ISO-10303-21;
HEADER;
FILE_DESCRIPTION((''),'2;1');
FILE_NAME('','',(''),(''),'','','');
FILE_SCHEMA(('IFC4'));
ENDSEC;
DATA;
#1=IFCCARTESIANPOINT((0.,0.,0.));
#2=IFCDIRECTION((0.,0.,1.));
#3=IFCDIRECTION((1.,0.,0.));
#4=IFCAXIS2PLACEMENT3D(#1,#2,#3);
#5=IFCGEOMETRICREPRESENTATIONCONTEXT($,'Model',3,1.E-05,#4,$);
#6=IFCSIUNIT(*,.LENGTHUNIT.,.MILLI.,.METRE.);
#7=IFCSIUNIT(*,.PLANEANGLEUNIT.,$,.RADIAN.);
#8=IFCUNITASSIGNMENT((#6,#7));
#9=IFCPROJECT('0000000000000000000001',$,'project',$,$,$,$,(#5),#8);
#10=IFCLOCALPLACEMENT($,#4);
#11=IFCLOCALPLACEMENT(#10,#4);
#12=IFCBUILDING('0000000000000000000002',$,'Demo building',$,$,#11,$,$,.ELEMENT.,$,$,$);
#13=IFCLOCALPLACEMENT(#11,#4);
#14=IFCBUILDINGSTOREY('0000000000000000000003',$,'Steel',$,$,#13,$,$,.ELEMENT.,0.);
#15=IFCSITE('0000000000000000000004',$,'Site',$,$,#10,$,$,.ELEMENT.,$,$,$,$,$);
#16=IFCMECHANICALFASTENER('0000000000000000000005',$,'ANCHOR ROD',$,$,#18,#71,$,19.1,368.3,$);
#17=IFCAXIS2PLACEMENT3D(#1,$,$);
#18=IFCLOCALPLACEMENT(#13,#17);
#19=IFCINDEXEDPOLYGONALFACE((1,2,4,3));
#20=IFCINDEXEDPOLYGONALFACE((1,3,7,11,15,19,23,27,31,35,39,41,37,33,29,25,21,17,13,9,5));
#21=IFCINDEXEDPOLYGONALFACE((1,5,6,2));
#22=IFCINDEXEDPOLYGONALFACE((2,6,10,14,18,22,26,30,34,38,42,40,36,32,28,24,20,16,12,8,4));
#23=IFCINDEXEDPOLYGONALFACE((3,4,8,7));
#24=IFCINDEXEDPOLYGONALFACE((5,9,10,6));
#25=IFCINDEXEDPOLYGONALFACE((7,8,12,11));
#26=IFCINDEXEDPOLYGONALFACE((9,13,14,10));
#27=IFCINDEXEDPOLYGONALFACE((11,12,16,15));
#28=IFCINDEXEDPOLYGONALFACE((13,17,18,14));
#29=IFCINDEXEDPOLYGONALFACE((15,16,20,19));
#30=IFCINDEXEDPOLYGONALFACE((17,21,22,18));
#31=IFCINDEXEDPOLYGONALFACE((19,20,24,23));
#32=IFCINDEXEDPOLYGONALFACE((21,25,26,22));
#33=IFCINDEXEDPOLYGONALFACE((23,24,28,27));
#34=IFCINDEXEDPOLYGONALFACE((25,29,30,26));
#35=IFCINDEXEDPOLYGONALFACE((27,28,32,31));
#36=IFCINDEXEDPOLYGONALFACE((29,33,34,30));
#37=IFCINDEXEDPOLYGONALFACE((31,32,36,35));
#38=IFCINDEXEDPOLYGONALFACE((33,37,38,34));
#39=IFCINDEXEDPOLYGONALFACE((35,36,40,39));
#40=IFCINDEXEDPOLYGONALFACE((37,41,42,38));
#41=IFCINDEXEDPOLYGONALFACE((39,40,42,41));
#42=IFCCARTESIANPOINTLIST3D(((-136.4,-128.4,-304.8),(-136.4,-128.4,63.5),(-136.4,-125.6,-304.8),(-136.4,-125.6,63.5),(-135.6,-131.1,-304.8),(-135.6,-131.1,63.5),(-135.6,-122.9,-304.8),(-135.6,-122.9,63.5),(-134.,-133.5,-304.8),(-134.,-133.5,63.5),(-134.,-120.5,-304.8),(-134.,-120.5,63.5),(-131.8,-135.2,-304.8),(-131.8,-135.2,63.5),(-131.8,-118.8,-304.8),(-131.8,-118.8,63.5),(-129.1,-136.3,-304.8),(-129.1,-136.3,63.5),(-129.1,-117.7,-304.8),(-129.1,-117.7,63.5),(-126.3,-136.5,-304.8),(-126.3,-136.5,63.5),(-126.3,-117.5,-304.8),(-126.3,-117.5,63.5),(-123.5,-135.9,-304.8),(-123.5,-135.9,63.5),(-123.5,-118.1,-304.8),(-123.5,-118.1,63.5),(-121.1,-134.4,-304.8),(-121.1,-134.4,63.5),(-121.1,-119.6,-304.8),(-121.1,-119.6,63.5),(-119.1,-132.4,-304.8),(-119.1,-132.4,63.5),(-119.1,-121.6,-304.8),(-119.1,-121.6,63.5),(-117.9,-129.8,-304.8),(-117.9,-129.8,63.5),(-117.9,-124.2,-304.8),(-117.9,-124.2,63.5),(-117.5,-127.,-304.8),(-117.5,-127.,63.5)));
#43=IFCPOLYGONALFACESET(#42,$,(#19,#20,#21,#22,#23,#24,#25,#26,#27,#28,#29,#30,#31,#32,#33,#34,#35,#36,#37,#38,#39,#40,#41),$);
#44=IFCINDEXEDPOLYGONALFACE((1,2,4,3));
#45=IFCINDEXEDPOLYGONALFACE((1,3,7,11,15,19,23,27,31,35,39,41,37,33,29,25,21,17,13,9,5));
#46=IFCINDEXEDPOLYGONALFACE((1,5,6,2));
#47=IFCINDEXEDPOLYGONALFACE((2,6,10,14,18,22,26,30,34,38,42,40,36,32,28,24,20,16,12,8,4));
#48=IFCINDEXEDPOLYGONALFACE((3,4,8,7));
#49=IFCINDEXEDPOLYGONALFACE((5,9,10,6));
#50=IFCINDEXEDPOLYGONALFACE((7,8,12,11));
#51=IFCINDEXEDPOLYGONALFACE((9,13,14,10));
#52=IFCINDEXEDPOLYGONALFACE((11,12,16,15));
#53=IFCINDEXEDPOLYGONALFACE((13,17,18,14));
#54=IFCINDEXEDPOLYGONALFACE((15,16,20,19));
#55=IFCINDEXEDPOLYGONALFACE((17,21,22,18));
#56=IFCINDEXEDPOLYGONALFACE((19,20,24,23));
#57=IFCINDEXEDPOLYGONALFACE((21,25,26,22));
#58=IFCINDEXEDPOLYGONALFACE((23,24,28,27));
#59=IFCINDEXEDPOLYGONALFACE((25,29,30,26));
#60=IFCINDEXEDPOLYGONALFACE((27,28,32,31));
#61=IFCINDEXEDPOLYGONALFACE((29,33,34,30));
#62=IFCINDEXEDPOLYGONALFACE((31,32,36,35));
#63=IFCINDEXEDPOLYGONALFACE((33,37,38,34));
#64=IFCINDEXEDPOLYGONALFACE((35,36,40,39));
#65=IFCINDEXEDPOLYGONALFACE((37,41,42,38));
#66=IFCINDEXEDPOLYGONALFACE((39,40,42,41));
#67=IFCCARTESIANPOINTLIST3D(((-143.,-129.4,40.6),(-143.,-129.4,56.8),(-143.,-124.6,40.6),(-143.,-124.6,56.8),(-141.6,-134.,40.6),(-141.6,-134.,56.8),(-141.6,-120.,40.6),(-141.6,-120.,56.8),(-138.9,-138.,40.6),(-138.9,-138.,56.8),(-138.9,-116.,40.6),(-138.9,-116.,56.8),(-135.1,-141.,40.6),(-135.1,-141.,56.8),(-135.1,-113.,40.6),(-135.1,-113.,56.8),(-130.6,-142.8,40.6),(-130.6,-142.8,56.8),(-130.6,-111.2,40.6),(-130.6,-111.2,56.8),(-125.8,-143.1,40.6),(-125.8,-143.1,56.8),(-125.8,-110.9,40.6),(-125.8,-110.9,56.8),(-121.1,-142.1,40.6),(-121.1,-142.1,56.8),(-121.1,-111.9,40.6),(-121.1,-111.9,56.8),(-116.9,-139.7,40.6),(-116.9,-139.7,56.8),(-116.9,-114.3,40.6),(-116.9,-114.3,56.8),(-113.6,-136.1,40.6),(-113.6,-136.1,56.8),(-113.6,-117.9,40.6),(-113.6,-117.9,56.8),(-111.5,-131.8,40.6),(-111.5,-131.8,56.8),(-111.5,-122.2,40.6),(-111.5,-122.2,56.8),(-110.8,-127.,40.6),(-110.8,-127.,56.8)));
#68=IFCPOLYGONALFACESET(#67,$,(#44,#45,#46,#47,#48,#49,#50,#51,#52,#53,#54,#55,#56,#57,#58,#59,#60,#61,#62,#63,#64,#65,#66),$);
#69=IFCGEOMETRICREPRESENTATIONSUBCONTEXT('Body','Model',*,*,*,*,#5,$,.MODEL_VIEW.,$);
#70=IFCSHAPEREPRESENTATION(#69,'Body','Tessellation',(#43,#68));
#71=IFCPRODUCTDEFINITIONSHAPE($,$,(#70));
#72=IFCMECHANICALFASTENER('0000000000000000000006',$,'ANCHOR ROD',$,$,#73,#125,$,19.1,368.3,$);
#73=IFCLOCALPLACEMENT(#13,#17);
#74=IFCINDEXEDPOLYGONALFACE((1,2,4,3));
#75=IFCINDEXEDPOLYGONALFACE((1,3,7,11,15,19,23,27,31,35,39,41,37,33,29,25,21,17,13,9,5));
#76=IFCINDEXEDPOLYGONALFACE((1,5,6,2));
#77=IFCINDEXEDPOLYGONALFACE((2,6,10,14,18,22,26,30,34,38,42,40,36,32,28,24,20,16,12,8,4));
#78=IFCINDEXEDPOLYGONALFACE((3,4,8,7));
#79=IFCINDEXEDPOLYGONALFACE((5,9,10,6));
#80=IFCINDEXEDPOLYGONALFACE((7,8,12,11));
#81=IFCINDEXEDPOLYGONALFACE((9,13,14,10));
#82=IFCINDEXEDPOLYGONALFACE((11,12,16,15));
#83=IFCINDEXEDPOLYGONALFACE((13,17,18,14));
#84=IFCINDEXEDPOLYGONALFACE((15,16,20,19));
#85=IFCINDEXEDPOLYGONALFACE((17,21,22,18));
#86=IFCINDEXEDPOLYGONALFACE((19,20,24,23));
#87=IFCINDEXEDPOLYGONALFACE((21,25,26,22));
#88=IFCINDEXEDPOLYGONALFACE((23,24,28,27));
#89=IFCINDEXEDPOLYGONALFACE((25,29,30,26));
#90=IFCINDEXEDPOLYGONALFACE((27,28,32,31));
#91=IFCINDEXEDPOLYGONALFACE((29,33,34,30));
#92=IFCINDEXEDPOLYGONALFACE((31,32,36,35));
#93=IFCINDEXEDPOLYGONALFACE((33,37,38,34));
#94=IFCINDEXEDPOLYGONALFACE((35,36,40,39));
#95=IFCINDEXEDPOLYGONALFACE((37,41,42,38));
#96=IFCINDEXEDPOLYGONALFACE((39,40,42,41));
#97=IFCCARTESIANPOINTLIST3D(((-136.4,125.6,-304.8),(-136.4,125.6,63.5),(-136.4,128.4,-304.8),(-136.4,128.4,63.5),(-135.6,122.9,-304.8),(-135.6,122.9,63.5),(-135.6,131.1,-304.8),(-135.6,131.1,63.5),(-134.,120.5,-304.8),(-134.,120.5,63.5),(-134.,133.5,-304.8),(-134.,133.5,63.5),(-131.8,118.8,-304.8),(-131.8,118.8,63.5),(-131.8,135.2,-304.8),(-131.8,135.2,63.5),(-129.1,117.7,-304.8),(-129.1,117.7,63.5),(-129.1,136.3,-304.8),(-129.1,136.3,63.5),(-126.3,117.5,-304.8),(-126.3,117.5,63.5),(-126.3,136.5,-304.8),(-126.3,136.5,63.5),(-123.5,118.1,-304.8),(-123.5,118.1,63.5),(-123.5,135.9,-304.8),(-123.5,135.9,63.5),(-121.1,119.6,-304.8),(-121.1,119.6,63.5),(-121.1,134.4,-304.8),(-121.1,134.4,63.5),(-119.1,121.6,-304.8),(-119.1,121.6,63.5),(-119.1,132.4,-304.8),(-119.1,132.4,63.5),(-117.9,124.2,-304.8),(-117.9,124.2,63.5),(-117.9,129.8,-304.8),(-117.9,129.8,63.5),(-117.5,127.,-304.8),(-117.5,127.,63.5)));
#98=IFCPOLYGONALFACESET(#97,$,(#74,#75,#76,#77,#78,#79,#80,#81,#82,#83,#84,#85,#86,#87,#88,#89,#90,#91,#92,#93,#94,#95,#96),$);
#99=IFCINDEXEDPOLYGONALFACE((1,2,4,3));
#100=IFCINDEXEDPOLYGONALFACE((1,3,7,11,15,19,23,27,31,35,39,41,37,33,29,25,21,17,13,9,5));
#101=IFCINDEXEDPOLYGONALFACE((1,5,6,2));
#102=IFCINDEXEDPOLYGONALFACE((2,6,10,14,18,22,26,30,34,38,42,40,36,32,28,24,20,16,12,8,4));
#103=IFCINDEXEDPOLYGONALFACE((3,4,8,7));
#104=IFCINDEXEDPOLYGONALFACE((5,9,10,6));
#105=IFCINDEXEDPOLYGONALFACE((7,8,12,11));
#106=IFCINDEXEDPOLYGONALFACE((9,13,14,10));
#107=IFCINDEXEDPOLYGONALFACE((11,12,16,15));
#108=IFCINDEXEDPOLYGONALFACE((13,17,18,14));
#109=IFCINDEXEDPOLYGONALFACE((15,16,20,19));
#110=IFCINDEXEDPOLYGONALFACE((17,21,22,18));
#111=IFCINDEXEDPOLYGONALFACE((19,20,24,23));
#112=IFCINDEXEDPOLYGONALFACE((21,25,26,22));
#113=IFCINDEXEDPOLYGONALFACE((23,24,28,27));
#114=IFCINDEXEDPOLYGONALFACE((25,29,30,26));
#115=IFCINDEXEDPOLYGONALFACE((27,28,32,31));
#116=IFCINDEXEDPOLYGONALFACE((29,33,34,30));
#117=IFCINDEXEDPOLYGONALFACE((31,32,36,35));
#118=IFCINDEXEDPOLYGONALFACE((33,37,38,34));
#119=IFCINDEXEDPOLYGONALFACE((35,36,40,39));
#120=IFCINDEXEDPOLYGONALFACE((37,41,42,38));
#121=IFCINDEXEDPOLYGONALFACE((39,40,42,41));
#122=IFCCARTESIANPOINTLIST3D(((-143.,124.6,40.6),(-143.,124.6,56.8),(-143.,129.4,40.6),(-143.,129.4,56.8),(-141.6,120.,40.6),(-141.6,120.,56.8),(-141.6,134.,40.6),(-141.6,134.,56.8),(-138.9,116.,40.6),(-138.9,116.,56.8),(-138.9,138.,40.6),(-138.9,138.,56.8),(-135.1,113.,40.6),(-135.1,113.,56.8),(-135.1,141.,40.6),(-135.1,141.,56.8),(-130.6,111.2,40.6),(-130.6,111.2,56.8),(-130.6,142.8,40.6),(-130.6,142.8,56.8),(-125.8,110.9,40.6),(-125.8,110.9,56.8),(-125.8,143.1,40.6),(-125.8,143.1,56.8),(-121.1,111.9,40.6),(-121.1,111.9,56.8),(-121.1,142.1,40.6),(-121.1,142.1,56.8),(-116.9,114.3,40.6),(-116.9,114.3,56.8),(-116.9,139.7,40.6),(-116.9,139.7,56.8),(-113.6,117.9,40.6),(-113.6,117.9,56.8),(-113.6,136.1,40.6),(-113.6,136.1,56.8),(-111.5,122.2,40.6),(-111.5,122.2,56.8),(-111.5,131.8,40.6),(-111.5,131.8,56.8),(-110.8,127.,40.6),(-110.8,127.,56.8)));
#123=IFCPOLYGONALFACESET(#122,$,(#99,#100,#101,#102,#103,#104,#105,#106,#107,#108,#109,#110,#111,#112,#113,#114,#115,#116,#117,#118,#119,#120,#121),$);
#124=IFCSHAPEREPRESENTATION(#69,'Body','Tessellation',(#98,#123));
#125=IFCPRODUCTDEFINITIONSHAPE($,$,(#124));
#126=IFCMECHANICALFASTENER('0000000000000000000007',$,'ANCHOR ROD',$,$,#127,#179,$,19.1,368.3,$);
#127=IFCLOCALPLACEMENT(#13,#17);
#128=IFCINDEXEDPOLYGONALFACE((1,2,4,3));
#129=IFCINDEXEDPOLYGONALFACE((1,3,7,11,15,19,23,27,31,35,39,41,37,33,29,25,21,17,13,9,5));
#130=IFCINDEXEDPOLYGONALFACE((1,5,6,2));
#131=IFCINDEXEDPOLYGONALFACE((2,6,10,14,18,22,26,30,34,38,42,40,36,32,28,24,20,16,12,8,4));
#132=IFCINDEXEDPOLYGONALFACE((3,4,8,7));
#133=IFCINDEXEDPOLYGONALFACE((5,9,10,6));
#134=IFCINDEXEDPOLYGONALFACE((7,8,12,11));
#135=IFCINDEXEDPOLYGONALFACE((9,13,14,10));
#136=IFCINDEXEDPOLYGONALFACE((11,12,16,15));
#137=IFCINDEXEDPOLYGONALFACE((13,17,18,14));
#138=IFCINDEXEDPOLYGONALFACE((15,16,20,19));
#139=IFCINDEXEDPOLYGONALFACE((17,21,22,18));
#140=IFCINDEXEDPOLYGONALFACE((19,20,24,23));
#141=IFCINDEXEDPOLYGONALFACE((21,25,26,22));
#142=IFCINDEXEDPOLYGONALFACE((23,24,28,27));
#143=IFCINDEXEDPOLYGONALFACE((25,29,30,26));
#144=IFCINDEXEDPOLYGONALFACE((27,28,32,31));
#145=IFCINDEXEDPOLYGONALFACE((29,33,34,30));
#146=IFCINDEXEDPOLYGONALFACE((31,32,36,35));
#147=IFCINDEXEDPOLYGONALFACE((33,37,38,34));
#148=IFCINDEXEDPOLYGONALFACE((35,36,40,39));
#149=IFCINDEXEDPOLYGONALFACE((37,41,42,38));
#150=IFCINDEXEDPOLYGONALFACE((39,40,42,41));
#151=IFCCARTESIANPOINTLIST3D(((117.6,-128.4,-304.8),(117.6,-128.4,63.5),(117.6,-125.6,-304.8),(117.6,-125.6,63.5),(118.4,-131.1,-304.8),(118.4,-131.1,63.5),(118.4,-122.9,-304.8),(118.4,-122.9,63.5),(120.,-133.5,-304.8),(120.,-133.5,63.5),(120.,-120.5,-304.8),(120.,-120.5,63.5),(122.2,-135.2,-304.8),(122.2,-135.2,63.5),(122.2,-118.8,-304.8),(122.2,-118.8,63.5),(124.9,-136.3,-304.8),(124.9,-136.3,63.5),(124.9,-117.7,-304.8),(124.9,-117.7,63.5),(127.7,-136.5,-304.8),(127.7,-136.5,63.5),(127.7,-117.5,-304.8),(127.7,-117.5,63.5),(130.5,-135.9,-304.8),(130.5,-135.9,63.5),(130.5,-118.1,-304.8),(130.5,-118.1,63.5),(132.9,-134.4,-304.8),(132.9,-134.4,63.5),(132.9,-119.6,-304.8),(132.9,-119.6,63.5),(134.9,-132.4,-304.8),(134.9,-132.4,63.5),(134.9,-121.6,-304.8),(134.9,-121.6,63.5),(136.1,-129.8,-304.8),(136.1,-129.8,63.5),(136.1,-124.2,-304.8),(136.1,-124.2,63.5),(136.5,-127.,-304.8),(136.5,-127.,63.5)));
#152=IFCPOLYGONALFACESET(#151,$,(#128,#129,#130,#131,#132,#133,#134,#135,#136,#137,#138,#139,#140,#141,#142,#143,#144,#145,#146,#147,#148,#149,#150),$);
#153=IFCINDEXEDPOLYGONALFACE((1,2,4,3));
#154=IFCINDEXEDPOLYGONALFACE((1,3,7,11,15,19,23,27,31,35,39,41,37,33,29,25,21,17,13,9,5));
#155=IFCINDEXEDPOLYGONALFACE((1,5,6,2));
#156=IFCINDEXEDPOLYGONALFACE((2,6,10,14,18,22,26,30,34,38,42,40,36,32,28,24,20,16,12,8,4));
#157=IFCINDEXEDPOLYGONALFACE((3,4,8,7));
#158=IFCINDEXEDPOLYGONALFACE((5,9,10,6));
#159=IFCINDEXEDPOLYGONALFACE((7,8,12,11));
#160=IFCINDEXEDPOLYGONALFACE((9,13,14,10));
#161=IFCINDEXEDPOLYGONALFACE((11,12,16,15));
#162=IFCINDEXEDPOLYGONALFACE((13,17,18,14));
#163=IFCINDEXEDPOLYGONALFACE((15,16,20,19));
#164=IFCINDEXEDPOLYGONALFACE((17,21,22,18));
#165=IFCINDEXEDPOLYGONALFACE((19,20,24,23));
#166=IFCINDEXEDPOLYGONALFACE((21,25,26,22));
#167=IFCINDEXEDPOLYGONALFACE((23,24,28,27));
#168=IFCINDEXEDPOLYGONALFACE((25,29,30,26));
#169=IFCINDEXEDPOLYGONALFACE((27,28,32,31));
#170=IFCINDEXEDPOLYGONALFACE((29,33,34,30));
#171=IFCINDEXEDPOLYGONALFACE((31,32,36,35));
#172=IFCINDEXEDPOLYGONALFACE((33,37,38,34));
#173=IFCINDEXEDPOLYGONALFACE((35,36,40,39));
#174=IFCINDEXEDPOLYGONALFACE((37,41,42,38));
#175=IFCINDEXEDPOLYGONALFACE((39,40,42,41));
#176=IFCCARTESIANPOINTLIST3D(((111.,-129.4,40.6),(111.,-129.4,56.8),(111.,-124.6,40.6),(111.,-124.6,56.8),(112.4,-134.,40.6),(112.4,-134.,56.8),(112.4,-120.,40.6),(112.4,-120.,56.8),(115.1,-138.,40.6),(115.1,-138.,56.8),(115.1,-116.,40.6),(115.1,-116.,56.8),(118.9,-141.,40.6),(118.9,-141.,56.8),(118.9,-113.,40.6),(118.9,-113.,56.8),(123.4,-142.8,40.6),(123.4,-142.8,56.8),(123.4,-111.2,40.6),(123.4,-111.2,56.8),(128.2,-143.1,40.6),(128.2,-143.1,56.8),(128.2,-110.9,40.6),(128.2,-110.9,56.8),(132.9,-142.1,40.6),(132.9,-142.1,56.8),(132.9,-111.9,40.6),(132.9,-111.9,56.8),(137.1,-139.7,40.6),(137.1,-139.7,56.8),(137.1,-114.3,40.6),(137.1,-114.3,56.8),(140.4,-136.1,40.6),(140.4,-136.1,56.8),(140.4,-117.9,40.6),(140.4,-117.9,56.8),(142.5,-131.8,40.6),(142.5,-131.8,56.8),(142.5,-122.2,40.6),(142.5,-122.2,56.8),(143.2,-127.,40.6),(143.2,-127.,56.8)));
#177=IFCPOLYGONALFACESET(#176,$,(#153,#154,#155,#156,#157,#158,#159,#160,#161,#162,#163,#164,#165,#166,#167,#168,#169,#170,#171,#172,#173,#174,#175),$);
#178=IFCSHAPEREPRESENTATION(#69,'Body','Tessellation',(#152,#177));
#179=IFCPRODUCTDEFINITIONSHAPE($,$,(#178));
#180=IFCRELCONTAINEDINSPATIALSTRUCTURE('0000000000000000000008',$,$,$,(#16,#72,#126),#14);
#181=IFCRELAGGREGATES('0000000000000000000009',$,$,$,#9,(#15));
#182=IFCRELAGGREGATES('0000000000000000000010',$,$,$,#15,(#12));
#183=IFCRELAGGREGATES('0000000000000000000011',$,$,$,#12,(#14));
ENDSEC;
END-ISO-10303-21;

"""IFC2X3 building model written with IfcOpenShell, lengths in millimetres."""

from ifc_helpers import new_model, si_unit, frame, origin, origin_with_axes, origin_2d, place, context, subcontext, project, spatial, circle, extrude, element, save


model = new_model("IFC2X3")

# Units and contexts
model_context = context("Model", 3, precision=1e-05, world=origin_with_axes())
body_context = subcontext(model_context, "Body", "Model", "MODEL_VIEW")
ifc_project = project(units=[si_unit("LENGTHUNIT", "METRE", prefix="MILLI"), si_unit("PLANEANGLEUNIT", "RADIAN")], contexts=[model_context])

# Site, building, storey
site_placement = place(None, origin_with_axes())
site = spatial("IfcSite", under=ifc_project, at=site_placement, Name="Site", CompositionType="ELEMENT")
building_placement = place(site_placement, origin_with_axes())
building = spatial("IfcBuilding", under=site, at=building_placement, Name="Demo building", CompositionType="ELEMENT")
placement = place(building_placement, origin_with_axes())
storey = spatial("IfcBuildingStorey", under=building, at=placement, Name="Steel", CompositionType="ELEMENT", Elevation=0.0)

# Mechanical fasteners
for number, where, z_axis, x_axis, name in (
    (1, (-127.0, -127.0, -304.8), (0.0, 0.0, 1.0), (1.0, 0.0, 0.0), "ANCHOR ROD"),
    (2, (-127.0, 127.0, -304.8), (0.0, 0.0, 1.0), (1.0, 0.0, 0.0), "ANCHOR ROD"),
    (3, (127.0, -127.0, -304.8), (0.0, 0.0, 1.0), (1.0, 0.0, 0.0), "ANCHOR ROD"),
):
    element("IfcMechanicalFastener", number, at=place(placement, frame(where, z_axis=z_axis, x_axis=x_axis)), inside=storey, Name=name, NominalDiameter=19.1, NominalLength=368.3, context=body_context, shape_type="SweptSolid", body=[
        extrude(circle(Radius=9.5, at=origin_2d()), origin(), (0.0, 0.0, 1.0), 368.3),
        extrude(circle(Radius=16.2, at=origin_2d()), frame((0.0, 0.0, 345.4)), (0.0, 0.0, 1.0), 16.2),
    ])

save(model, "model.ifc")
